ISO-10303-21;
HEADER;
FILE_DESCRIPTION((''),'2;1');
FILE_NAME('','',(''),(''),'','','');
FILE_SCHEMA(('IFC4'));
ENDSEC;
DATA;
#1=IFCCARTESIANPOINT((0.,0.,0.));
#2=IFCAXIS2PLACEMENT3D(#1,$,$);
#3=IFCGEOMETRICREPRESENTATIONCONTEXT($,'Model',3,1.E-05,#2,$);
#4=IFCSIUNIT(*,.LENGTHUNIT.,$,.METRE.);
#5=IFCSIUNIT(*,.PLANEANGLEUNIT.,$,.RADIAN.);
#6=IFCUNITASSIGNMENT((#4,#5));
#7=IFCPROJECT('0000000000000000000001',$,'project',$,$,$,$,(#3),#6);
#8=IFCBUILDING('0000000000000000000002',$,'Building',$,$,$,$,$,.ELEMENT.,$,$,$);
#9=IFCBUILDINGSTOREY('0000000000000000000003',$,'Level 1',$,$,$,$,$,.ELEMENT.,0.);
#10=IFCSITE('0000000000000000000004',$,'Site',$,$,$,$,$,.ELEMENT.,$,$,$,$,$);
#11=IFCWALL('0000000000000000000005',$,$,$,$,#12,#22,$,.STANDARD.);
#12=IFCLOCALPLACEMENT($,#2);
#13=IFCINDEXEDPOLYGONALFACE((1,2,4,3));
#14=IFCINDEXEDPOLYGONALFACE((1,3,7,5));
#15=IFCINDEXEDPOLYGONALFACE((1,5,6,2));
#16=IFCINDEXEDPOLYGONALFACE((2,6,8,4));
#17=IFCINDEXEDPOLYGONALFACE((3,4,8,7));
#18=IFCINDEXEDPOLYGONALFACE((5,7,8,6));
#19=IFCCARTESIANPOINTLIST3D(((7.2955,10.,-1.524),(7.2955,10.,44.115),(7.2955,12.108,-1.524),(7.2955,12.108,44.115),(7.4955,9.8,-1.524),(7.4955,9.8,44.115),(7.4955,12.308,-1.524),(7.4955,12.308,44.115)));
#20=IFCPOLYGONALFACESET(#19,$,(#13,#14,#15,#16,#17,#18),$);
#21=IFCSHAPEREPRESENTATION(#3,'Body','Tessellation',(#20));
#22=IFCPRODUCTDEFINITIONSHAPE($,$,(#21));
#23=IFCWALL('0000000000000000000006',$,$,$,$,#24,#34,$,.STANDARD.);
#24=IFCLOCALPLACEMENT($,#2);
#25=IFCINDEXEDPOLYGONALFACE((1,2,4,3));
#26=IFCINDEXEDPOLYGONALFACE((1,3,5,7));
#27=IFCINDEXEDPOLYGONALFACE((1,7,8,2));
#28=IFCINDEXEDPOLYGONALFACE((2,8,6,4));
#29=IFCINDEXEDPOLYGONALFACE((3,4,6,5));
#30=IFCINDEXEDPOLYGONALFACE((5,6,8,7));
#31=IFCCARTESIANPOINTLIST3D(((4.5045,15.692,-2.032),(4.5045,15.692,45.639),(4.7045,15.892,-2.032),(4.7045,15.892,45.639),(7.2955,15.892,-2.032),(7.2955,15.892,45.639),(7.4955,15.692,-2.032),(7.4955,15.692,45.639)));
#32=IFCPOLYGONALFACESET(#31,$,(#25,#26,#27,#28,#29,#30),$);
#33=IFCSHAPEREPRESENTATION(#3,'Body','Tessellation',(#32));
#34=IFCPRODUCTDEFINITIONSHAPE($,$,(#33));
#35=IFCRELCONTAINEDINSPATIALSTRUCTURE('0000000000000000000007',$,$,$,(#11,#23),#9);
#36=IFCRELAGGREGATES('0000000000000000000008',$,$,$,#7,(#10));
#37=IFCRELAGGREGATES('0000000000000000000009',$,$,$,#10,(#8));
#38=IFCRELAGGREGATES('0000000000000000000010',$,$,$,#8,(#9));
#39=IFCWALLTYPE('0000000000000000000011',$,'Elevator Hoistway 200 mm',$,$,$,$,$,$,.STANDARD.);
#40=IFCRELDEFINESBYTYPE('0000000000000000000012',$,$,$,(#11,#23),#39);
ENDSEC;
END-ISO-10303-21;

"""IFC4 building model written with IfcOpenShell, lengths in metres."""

from ifc_helpers import new_model, si_unit, frame, origin, place, context, project, spatial, polyline, outline, extrude, type_object, element, save


model = new_model("IFC4")

# Units and contexts
model_context = context("Model", 3, precision=1e-05, world=origin())
ifc_project = project(units=[si_unit("LENGTHUNIT", "METRE"), si_unit("PLANEANGLEUNIT", "RADIAN")], contexts=[model_context])

# Site, building, storey
site = spatial("IfcSite", under=ifc_project, Name="Site", CompositionType="ELEMENT")
building = spatial("IfcBuilding", under=site, Name="Building", CompositionType="ELEMENT")
storey = spatial("IfcBuildingStorey", under=building, Name="Level 1", CompositionType="ELEMENT", Elevation=0.0)

# Shared definitions
wall_type = type_object("IfcWallType", Name="Elevator Hoistway 200 mm", PredefinedType="STANDARD")

# Walls
wall_1_placement = place(None, frame((7.3955, 9.9, -1.524), z_axis=(0.0, 0.0, 1.0), x_axis=(0.0, 1.0, 0.0)))
element("IfcWall", 1, at=wall_1_placement, inside=storey, type_object=wall_type, PredefinedType="STANDARD", context=model_context, shape_type="SweptSolid", body=[
    extrude(outline(polyline([(-0.1, -0.1), (2.408, -0.1), (2.208, 0.1), (0.1, 0.1), (-0.1, -0.1)])), origin(), (0.0, 0.0, 1.0), 45.639),
])
wall_2_placement = place(None, frame((4.6045, 15.792, -2.032), z_axis=(0.0, 0.0, 1.0), x_axis=(1.0, 0.0, 0.0)))
element("IfcWall", 2, at=wall_2_placement, inside=storey, type_object=wall_type, PredefinedType="STANDARD", context=model_context, shape_type="SweptSolid", body=[
    extrude(outline(polyline([(-0.1, -0.1), (2.891, -0.1), (2.691, 0.1), (0.1, 0.1), (-0.1, -0.1)])), origin(), (0.0, 0.0, 1.0), 47.671),
])

save(model, "model.ifc")
